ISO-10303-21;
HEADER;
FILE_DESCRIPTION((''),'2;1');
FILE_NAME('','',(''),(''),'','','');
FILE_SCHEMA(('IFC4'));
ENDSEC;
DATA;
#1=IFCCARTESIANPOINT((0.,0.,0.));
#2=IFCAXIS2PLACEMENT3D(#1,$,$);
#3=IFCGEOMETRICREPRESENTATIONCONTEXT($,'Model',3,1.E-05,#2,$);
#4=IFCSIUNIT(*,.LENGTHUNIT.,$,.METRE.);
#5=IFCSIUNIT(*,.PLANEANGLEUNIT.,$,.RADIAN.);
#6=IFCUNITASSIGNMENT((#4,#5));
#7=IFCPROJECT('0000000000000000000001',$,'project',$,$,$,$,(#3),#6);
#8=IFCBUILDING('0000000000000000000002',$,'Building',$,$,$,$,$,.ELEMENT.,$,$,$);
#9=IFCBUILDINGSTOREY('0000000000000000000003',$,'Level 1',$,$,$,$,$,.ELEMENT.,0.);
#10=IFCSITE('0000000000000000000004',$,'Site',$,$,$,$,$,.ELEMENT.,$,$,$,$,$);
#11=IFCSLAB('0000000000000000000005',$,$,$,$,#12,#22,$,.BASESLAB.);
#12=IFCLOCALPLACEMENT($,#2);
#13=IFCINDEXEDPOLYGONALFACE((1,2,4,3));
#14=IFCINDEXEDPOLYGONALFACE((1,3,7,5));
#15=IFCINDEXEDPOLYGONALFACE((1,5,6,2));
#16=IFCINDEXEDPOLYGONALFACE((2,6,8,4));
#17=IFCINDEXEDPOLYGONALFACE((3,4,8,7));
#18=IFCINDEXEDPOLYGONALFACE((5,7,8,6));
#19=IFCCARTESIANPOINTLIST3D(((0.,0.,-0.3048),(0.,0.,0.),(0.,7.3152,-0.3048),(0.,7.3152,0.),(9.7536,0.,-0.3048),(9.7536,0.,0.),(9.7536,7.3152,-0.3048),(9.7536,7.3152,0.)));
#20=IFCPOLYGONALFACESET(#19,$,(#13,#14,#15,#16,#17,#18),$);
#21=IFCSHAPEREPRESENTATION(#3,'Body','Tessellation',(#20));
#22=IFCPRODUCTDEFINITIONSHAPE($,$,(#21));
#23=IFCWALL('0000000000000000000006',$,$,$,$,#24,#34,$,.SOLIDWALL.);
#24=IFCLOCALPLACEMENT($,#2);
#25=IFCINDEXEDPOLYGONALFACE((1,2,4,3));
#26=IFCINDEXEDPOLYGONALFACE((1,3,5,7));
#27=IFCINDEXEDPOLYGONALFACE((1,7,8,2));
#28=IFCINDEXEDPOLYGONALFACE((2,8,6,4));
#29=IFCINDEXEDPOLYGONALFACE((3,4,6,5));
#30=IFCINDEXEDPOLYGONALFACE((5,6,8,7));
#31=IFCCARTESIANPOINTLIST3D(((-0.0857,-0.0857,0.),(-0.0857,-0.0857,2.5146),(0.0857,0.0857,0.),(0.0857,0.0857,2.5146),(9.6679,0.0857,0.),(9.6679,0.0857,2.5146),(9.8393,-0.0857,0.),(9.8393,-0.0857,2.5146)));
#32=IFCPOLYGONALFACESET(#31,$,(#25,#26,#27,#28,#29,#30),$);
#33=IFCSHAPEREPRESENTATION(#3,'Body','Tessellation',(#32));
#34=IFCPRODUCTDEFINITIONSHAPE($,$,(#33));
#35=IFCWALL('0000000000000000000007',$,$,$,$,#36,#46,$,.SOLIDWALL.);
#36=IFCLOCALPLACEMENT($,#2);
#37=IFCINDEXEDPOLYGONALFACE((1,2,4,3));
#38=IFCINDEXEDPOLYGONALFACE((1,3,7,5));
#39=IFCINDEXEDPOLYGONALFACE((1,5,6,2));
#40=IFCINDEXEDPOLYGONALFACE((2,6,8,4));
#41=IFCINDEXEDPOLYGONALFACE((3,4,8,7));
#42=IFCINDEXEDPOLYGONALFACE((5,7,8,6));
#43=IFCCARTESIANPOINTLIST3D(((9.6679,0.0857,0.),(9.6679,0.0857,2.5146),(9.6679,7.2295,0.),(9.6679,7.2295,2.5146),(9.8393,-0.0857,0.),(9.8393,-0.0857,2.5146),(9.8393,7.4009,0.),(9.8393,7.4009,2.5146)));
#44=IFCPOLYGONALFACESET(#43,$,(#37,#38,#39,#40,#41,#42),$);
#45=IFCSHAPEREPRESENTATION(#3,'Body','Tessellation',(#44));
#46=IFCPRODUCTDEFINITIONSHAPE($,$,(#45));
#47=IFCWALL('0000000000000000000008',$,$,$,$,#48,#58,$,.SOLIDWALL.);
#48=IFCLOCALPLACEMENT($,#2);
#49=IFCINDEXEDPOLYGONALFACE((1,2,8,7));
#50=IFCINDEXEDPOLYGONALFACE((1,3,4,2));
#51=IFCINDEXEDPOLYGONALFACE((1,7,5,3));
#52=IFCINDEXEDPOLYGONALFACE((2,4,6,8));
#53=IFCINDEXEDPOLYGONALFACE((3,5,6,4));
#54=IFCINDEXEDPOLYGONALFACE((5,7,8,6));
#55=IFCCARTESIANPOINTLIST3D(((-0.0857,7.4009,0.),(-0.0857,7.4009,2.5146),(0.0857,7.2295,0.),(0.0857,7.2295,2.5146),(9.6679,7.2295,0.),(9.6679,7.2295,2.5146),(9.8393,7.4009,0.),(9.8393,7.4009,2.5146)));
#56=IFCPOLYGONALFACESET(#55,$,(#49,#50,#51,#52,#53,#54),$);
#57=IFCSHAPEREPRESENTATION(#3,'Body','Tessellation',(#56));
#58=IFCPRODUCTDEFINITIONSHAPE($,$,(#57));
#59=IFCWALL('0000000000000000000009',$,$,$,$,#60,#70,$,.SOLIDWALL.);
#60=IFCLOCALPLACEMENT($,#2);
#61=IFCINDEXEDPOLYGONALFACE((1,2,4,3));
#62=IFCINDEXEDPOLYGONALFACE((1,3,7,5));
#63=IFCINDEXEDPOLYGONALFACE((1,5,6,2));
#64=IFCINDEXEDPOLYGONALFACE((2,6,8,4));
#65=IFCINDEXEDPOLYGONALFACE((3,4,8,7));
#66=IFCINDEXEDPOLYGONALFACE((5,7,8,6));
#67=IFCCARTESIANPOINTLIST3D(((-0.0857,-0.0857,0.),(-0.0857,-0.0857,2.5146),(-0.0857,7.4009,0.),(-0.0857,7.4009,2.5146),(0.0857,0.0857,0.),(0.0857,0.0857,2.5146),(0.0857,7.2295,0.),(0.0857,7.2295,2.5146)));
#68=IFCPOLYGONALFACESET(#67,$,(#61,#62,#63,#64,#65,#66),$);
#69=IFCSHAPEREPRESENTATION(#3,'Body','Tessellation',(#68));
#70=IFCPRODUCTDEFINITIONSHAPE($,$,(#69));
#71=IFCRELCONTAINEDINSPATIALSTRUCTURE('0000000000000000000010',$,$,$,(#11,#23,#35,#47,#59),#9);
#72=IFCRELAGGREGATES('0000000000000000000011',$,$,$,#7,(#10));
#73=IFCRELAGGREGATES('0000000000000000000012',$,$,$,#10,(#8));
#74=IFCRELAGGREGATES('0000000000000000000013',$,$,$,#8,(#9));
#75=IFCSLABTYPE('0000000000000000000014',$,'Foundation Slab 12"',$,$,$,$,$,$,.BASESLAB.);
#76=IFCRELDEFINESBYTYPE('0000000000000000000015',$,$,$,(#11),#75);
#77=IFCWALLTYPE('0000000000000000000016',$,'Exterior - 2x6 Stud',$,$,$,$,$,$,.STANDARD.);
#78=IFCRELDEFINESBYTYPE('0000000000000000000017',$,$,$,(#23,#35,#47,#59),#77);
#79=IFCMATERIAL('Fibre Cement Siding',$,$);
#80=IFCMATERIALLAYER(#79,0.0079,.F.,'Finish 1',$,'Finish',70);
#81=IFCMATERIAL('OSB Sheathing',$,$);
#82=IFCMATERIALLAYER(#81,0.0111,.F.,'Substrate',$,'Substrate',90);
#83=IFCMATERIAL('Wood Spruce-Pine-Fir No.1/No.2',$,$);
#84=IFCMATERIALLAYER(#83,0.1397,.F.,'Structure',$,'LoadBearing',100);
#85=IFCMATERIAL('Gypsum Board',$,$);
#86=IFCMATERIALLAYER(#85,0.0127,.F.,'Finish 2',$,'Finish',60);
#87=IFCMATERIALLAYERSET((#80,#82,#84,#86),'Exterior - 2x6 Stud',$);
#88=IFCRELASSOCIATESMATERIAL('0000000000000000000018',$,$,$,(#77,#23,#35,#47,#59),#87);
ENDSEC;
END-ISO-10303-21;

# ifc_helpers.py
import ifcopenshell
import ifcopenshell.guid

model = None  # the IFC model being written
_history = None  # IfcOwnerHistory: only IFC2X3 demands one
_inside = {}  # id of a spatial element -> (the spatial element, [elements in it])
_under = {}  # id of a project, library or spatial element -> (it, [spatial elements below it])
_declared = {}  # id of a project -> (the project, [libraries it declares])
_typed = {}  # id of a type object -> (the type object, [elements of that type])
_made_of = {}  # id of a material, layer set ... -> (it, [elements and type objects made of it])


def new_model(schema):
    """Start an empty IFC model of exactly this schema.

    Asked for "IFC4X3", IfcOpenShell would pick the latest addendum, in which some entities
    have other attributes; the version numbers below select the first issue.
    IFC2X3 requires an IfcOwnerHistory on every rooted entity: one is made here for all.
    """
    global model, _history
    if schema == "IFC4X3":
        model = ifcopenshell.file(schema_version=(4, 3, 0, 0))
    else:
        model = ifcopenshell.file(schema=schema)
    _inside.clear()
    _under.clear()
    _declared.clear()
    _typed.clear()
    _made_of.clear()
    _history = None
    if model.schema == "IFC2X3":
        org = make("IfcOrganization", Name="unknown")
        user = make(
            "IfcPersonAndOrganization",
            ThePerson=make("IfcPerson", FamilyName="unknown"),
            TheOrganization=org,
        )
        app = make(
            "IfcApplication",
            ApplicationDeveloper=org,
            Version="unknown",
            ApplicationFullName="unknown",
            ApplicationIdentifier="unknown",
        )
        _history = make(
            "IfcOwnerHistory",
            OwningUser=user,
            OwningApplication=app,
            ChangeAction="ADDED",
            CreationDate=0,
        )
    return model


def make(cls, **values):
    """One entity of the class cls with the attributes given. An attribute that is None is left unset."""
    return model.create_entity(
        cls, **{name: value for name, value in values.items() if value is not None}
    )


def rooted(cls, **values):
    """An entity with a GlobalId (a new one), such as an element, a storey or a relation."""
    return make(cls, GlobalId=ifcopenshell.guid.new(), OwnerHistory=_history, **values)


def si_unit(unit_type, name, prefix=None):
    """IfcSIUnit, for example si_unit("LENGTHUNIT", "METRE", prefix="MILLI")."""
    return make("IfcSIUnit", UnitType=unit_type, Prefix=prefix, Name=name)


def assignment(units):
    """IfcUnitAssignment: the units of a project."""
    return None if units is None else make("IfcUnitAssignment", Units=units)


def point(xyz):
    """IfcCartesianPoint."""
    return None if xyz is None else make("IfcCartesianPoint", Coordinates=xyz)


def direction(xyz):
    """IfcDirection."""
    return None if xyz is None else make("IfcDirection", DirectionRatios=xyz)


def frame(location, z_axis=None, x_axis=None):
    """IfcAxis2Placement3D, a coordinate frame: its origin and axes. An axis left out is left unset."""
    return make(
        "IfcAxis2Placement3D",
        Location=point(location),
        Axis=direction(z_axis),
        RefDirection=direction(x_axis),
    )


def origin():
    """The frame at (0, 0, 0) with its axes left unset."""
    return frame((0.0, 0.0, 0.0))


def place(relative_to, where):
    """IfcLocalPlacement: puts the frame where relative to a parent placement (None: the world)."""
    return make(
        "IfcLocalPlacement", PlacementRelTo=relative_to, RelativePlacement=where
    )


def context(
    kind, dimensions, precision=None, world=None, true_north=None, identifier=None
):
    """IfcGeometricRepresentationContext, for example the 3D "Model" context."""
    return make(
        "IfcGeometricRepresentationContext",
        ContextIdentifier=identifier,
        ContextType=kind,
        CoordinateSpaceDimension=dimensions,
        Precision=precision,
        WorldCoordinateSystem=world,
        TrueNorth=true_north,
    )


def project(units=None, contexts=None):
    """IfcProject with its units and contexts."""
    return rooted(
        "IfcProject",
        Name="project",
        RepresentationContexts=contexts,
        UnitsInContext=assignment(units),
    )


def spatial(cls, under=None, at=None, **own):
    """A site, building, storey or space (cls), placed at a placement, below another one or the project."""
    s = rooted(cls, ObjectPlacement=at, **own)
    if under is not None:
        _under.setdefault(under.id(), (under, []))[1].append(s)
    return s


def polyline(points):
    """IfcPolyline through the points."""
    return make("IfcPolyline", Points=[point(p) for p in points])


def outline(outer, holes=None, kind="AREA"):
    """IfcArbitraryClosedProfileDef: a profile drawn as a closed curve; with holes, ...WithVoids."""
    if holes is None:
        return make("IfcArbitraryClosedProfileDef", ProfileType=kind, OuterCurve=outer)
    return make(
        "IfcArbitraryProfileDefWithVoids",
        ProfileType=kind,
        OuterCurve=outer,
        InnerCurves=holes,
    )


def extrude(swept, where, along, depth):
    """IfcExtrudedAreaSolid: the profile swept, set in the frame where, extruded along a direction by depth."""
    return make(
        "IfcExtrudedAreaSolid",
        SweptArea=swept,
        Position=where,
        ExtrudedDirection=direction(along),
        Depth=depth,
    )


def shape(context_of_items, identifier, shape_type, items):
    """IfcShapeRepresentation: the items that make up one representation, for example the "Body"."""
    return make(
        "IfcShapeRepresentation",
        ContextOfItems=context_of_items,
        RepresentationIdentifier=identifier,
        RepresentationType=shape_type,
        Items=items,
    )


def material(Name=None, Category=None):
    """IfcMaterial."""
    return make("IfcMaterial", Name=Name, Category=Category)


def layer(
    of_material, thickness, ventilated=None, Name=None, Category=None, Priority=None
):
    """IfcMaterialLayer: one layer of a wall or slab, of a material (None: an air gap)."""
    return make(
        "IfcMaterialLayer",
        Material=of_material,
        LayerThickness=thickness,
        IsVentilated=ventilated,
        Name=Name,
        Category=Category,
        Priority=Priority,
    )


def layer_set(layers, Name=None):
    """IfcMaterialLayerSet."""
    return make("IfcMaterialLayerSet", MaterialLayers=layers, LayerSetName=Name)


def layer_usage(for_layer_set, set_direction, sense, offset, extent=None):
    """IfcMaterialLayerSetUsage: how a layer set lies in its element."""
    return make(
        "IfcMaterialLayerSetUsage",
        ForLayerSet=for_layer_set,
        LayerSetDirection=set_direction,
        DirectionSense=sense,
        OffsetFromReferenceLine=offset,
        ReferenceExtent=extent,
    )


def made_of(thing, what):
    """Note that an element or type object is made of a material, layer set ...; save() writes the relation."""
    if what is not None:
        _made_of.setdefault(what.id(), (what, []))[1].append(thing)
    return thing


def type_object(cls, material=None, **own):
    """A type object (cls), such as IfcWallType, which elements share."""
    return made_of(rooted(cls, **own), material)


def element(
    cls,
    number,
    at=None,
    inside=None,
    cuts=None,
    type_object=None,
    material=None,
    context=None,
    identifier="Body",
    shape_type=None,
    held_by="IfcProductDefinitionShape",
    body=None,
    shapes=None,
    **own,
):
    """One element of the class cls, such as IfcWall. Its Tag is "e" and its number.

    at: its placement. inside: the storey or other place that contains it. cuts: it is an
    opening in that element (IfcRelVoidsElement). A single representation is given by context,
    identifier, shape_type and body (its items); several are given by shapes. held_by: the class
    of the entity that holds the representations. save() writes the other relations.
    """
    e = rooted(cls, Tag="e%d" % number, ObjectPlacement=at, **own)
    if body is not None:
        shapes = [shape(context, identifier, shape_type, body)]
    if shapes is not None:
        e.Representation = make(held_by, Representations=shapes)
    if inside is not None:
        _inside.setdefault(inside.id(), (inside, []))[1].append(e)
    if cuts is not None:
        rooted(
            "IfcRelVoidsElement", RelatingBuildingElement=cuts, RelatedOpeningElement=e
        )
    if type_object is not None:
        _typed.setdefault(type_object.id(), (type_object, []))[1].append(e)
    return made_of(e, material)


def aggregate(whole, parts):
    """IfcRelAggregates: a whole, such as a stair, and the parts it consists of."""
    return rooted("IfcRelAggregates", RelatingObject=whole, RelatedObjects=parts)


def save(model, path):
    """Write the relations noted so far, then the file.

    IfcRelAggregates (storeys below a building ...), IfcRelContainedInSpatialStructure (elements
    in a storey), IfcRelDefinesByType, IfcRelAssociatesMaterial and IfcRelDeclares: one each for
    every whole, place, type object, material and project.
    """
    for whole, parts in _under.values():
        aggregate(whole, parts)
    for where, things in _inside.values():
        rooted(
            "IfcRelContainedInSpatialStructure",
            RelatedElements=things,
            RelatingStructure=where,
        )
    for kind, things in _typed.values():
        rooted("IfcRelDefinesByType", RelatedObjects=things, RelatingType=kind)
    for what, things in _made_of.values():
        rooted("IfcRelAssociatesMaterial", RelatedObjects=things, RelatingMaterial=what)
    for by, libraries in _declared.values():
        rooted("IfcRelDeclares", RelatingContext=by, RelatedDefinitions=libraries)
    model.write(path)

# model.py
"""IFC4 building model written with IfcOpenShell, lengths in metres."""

from ifc_helpers import new_model, si_unit, frame, origin, place, context, project, spatial, polyline, outline, extrude, material, layer, layer_set, layer_usage, type_object, element, save


model = new_model("IFC4")

# Units and contexts
model_context = context("Model", 3, precision=1e-05, world=origin())
ifc_project = project(units=[si_unit("LENGTHUNIT", "METRE"), si_unit("PLANEANGLEUNIT", "RADIAN")], contexts=[model_context])

# Site, building, storey
site = spatial("IfcSite", under=ifc_project, Name="Site", CompositionType="ELEMENT")
building = spatial("IfcBuilding", under=site, Name="Building", CompositionType="ELEMENT")
storey = spatial("IfcBuildingStorey", under=building, Name="Level 1", CompositionType="ELEMENT", Elevation=0.0)

# Slab
slab_type = type_object("IfcSlabType", Name="Foundation Slab 12\"", PredefinedType="BASESLAB")
slab_placement = place(None, origin())
element("IfcSlab", 1, at=slab_placement, inside=storey, type_object=slab_type, PredefinedType="BASESLAB", context=model_context, shape_type="SweptSolid", body=[
    extrude(outline(polyline([(0.0, 0.0), (9.7536, 0.0), (9.7536, 7.3152), (0.0, 7.3152), (0.0, 0.0)])), origin(), (0.0, 0.0, -1.0), 0.3048),
])

# Walls
ifc_material_1 = material(Name="Fibre Cement Siding")
ifc_layer_1 = layer(ifc_material_1, 0.0079, ventilated=False, Name="Finish 1", Category="Finish", Priority=70)
ifc_material_2 = material(Name="OSB Sheathing")
ifc_layer_2 = layer(ifc_material_2, 0.0111, ventilated=False, Name="Substrate", Category="Substrate", Priority=90)
ifc_material_3 = material(Name="Wood Spruce-Pine-Fir No.1/No.2")
ifc_layer_3 = layer(ifc_material_3, 0.1397, ventilated=False, Name="Structure", Category="LoadBearing", Priority=100)
ifc_material_4 = material(Name="Gypsum Board")
ifc_layer_4 = layer(ifc_material_4, 0.0127, ventilated=False, Name="Finish 2", Category="Finish", Priority=60)
ifc_layer_set = layer_set([ifc_layer_1, ifc_layer_2, ifc_layer_3, ifc_layer_4], Name="Exterior - 2x6 Stud")
ifc_layer_usage = layer_usage(ifc_layer_set, "AXIS2", "POSITIVE", -0.0857)
wall_type = type_object("IfcWallType", Name="Exterior - 2x6 Stud", PredefinedType="STANDARD", material=ifc_layer_set)
wall_1_placement = place(None, frame((9.7536, 0.0, 0.0), z_axis=(0.0, 0.0, 1.0), x_axis=(-1.0, 0.0, 0.0)))
element("IfcWall", 2, at=wall_1_placement, inside=storey, type_object=wall_type, material=ifc_layer_usage, PredefinedType="SOLIDWALL", context=model_context, shape_type="SweptSolid", body=[
    extrude(outline(polyline([(0.0857, -0.0857), (9.6679, -0.0857), (9.8393, 0.0857), (-0.0857, 0.0857), (0.0857, -0.0857)])), origin(), (0.0, 0.0, 1.0), 2.5146),
])
wall_2_placement = place(None, frame((9.7536, 7.3152, 0.0), z_axis=(0.0, 0.0, 1.0), x_axis=(0.0, -1.0, 0.0)))
element("IfcWall", 3, at=wall_2_placement, inside=storey, type_object=wall_type, material=ifc_layer_usage, PredefinedType="SOLIDWALL", context=model_context, shape_type="SweptSolid", body=[
    extrude(outline(polyline([(0.0857, -0.0857), (7.2295, -0.0857), (7.4009, 0.0857), (-0.0857, 0.0857), (0.0857, -0.0857)])), origin(), (0.0, 0.0, 1.0), 2.5146),
])
wall_3_placement = place(None, frame((0.0, 7.3152, 0.0), z_axis=(0.0, 0.0, 1.0), x_axis=(1.0, 0.0, 0.0)))
element("IfcWall", 4, at=wall_3_placement, inside=storey, type_object=wall_type, material=ifc_layer_usage, PredefinedType="SOLIDWALL", context=model_context, shape_type="SweptSolid", body=[
    extrude(outline(polyline([(0.0857, -0.0857), (9.6679, -0.0857), (9.8393, 0.0857), (-0.0857, 0.0857), (0.0857, -0.0857)])), origin(), (0.0, 0.0, 1.0), 2.5146),
])
wall_4_placement = place(None, frame((0.0, 0.0, 0.0), z_axis=(0.0, 0.0, 1.0), x_axis=(0.0, 1.0, 0.0)))
element("IfcWall", 5, at=wall_4_placement, inside=storey, type_object=wall_type, material=ifc_layer_usage, PredefinedType="SOLIDWALL", context=model_context, shape_type="SweptSolid", body=[
    extrude(outline(polyline([(0.0857, -0.0857), (7.2295, -0.0857), (7.4009, 0.0857), (-0.0857, 0.0857), (0.0857, -0.0857)])), origin(), (0.0, 0.0, 1.0), 2.5146),
])

save(model, "model.ifc")
